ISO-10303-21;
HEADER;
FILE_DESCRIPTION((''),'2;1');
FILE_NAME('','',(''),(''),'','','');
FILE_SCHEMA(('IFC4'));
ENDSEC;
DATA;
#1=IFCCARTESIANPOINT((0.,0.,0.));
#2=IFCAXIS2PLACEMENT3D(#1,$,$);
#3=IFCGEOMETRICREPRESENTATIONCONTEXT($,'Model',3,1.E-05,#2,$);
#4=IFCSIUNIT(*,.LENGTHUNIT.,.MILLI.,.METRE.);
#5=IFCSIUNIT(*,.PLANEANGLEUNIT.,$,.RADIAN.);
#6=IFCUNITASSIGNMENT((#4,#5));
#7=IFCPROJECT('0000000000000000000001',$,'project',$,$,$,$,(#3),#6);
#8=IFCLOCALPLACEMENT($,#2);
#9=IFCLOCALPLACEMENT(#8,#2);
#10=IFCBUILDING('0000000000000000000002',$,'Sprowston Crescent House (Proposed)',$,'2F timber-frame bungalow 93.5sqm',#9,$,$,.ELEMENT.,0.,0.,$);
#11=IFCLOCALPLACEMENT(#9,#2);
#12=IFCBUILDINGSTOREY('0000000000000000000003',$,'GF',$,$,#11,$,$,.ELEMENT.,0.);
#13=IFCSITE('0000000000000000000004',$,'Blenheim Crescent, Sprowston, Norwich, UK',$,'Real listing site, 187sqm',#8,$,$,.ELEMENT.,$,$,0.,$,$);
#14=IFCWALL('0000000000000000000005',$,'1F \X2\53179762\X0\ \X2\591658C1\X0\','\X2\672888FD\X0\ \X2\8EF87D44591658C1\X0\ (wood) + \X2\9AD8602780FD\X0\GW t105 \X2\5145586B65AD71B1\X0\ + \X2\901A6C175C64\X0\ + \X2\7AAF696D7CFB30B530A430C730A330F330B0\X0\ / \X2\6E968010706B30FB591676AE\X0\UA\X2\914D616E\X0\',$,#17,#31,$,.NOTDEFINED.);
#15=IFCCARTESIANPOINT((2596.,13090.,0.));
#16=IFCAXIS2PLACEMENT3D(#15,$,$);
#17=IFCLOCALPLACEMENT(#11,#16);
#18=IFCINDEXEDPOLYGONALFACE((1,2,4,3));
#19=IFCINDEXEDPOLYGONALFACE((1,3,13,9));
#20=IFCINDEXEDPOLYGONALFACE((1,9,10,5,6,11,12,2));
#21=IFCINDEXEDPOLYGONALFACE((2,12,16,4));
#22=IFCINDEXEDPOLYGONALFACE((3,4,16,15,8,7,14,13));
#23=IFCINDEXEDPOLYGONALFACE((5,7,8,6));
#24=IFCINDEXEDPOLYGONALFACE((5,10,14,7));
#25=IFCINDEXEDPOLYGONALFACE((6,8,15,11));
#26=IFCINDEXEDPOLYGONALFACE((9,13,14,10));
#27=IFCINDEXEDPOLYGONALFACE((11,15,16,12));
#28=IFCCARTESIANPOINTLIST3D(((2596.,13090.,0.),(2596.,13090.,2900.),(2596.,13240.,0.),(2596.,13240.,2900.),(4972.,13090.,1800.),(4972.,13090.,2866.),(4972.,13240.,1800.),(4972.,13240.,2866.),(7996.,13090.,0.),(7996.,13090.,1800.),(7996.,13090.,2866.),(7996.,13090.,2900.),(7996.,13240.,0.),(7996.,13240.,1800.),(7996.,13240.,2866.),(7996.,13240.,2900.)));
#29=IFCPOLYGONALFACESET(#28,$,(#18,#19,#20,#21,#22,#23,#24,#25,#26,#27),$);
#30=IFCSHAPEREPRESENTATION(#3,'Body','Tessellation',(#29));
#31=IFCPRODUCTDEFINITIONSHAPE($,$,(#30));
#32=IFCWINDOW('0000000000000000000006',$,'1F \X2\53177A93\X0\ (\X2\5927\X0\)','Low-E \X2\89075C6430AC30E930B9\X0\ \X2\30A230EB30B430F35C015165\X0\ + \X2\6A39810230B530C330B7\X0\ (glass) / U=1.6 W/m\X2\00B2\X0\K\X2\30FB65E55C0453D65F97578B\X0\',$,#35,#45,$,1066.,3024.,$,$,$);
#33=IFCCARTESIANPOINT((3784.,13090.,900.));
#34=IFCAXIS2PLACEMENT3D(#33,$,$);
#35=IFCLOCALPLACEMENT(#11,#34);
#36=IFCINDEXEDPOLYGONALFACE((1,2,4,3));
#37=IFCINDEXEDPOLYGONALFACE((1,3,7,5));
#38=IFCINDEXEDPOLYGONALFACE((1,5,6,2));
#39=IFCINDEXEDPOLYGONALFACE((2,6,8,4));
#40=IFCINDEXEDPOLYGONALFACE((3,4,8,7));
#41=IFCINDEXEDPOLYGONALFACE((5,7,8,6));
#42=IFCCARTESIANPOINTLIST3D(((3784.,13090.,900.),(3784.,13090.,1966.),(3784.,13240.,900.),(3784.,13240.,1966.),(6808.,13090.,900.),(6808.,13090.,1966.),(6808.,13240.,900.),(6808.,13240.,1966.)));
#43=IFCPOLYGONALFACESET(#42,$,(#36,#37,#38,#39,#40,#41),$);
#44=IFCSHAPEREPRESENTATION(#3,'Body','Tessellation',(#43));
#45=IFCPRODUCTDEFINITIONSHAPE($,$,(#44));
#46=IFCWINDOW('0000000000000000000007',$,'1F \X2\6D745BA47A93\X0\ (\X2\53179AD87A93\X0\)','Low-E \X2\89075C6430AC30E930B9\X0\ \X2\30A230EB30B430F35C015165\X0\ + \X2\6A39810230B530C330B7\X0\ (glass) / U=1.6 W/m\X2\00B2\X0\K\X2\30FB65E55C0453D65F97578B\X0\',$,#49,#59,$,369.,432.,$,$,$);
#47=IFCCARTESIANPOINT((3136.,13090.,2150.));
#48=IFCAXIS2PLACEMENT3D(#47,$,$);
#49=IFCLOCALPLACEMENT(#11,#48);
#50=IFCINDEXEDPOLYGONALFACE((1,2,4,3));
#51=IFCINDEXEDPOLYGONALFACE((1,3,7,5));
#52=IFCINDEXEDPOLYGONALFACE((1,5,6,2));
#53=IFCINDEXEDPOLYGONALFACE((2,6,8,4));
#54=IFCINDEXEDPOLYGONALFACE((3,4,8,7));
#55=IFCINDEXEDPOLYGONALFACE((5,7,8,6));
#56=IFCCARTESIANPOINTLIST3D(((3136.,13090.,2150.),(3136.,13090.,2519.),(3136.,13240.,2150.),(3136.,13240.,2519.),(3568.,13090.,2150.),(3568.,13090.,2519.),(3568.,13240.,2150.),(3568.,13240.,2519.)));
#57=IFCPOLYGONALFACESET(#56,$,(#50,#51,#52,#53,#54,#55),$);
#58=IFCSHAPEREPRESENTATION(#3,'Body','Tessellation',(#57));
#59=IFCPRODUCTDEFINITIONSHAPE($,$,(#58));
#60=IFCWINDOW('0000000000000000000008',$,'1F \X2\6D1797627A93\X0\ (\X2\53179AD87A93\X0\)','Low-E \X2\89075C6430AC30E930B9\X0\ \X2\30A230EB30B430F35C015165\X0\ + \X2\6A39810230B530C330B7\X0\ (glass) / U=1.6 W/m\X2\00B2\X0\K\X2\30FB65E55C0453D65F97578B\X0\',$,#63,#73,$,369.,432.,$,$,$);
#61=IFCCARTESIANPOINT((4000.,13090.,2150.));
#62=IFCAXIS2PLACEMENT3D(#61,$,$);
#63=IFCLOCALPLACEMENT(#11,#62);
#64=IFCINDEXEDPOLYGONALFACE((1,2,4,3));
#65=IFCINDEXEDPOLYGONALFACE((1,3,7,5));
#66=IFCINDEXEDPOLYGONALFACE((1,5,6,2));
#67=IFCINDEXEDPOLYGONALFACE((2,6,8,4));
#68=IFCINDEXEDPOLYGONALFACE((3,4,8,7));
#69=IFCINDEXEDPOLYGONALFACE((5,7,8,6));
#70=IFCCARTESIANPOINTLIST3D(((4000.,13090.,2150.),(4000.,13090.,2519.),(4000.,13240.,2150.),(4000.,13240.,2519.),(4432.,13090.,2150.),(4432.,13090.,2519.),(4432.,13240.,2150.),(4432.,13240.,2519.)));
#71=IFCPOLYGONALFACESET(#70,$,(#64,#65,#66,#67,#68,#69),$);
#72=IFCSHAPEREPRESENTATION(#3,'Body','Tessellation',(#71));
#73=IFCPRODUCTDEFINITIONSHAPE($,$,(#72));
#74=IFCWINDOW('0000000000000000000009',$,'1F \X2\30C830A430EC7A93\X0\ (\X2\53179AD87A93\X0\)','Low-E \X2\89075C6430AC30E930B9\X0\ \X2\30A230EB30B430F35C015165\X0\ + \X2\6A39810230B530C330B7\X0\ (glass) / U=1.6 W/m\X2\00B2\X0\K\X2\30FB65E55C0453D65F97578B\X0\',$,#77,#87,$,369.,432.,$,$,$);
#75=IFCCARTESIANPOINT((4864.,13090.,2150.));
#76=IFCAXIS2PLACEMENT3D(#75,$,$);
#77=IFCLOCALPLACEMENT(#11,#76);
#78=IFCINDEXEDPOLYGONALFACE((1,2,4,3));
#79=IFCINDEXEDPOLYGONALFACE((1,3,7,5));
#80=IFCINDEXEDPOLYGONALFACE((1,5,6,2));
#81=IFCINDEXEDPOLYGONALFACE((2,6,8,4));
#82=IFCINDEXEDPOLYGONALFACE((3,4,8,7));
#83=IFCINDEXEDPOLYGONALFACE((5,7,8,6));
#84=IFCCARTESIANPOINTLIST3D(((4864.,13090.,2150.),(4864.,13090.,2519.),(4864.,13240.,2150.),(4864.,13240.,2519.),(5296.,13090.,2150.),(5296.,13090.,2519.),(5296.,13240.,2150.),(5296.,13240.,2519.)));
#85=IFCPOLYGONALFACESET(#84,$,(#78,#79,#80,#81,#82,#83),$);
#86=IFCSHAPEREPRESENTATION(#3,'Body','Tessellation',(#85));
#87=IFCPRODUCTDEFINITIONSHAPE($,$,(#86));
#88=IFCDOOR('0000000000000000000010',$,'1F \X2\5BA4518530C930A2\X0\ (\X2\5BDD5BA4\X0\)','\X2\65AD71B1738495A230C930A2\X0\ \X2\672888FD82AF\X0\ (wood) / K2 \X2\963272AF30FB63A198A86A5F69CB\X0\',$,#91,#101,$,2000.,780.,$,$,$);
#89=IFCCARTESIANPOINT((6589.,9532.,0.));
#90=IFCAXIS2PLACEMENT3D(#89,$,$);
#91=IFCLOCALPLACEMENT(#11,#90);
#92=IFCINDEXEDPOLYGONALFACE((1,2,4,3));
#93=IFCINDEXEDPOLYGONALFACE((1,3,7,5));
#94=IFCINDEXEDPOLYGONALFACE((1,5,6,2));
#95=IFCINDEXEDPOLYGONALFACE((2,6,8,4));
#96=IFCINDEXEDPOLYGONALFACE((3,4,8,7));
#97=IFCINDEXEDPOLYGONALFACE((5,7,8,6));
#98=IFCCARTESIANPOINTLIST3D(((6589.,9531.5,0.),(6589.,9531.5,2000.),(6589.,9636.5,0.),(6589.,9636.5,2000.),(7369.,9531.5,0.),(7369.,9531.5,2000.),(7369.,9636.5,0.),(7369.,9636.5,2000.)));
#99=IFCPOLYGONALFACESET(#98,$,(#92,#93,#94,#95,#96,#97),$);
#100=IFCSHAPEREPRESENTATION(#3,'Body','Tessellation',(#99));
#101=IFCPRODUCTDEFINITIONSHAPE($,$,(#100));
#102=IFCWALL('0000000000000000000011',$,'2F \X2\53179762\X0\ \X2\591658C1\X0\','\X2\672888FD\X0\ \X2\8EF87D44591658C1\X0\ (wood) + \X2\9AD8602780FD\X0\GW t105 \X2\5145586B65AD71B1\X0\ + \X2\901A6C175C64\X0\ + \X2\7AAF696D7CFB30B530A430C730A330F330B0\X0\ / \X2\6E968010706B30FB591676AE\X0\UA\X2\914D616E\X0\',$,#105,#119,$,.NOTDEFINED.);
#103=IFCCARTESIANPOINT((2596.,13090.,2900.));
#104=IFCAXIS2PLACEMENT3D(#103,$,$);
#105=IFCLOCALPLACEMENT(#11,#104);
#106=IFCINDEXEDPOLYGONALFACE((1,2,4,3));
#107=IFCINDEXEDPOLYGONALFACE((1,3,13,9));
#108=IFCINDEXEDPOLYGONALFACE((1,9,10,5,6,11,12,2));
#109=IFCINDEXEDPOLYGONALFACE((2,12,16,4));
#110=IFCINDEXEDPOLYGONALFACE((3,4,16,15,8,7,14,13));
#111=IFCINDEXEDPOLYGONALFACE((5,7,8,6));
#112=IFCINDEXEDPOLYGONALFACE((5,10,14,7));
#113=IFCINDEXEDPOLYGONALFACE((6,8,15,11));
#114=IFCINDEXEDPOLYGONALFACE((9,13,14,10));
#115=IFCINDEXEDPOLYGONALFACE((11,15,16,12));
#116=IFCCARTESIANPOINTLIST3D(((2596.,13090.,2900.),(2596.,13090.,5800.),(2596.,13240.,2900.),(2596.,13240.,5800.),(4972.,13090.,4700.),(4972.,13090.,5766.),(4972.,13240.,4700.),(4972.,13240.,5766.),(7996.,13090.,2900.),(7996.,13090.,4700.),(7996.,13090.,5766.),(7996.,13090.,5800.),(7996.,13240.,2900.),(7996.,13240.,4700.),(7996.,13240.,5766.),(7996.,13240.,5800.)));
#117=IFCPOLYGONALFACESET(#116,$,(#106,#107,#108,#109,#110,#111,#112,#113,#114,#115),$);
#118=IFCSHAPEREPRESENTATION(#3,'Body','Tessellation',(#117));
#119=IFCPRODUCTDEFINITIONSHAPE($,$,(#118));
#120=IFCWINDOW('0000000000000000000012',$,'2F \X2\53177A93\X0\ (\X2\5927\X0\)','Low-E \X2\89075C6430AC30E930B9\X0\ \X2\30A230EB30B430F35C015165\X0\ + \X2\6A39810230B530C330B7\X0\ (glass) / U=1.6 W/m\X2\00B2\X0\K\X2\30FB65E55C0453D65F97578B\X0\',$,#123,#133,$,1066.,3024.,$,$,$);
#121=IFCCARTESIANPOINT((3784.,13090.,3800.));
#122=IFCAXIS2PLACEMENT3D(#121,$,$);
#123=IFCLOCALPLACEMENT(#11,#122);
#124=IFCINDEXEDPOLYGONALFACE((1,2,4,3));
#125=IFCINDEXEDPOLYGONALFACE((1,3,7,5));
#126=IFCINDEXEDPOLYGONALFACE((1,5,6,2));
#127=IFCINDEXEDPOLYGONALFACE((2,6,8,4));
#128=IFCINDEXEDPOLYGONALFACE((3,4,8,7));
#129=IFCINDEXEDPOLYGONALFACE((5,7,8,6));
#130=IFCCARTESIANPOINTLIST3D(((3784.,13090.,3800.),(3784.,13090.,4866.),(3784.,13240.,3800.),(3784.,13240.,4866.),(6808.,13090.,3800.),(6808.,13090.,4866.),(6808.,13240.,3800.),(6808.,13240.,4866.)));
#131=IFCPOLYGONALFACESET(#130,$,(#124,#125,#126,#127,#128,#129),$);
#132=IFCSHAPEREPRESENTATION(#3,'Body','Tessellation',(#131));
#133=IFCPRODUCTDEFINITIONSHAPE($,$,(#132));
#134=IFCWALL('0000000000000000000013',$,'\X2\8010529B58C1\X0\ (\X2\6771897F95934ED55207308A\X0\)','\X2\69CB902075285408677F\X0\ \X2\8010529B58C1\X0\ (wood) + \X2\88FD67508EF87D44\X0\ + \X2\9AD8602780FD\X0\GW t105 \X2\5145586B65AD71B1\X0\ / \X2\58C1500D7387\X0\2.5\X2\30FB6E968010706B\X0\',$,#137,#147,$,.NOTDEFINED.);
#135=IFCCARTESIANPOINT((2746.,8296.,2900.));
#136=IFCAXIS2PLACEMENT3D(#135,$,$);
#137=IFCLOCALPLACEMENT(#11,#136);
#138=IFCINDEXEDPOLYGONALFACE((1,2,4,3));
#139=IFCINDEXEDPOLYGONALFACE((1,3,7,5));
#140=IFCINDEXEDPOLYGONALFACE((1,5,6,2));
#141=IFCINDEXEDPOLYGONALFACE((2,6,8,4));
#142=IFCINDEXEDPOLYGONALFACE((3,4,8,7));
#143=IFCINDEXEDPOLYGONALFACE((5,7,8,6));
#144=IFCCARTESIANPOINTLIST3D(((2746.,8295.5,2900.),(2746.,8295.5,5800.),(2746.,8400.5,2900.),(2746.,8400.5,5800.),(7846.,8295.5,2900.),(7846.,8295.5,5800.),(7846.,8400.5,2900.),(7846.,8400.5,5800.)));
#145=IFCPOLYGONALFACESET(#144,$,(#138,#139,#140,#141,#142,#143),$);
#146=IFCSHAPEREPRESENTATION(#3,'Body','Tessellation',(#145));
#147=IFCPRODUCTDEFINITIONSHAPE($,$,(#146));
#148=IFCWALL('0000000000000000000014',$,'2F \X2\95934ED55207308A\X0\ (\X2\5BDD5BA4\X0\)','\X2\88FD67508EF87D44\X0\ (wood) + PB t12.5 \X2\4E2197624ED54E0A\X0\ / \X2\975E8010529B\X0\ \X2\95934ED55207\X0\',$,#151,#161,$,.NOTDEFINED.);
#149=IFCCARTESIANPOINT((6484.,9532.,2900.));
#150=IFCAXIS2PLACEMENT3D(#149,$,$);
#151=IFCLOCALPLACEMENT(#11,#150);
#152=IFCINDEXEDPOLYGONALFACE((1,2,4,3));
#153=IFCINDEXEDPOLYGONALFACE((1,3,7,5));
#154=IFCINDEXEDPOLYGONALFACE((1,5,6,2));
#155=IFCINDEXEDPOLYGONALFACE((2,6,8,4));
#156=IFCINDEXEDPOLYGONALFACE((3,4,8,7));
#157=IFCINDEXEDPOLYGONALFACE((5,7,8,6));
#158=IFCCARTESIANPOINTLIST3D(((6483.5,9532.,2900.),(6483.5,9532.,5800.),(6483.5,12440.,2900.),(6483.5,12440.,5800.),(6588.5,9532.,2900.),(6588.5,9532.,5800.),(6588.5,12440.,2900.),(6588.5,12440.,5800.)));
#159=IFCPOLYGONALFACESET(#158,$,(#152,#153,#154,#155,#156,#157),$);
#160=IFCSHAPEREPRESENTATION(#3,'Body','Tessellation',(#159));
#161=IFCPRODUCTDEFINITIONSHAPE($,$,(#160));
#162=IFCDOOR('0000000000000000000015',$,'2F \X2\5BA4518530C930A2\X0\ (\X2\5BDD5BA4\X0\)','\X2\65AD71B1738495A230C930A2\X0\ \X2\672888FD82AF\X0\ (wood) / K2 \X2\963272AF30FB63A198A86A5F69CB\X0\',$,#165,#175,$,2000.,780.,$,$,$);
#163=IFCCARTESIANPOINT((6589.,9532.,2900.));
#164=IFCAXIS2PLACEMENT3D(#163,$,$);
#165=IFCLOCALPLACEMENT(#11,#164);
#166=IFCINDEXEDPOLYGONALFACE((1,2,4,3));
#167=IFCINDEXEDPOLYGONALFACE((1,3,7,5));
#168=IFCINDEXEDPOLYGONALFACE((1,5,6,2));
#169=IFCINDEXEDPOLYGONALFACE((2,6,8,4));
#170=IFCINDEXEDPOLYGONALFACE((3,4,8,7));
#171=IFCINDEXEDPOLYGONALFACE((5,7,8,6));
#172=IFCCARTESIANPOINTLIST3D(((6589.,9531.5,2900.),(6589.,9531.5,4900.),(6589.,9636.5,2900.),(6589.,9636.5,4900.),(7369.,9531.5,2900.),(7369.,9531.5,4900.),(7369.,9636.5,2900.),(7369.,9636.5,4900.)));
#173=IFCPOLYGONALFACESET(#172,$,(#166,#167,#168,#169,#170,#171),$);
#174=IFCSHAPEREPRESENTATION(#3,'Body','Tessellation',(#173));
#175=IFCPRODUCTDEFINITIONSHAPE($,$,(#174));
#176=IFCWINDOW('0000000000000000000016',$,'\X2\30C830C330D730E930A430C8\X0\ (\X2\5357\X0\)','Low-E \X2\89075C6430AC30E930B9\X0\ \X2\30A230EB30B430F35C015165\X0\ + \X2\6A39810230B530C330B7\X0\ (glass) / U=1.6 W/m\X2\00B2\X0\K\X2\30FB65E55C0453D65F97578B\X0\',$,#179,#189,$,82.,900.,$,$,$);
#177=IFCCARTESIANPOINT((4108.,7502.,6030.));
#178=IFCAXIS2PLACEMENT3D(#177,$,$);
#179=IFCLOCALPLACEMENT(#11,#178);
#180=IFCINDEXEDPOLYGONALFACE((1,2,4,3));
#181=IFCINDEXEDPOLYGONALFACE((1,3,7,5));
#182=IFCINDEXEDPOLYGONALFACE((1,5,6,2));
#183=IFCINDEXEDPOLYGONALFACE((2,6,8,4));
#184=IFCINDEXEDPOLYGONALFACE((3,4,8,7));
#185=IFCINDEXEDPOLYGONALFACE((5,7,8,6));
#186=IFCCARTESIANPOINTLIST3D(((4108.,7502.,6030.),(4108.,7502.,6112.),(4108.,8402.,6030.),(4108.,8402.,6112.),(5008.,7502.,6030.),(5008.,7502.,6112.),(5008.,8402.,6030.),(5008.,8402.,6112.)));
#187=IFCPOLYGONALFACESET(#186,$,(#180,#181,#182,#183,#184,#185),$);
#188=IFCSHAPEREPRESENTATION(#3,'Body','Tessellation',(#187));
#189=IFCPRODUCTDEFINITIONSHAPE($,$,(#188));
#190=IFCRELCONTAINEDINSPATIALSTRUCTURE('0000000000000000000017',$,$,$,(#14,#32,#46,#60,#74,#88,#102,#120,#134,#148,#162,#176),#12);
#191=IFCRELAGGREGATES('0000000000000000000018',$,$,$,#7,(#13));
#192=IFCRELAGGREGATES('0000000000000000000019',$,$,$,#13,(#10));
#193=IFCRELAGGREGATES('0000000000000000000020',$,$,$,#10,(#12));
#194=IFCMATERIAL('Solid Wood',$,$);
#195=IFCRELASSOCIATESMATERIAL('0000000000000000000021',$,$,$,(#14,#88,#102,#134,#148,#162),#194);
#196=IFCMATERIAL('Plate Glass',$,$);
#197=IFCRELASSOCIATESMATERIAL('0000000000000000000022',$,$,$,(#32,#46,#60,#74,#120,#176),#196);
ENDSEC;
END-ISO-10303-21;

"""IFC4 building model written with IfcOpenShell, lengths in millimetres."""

from ifc_helpers import new_model, si_unit, frame, frame_2d, origin, place, context, project, spatial, rectangle, extrude, material, element, fill, save


model = new_model("IFC4")

# Units and contexts
model_context = context("Model", 3, precision=1e-05, world=origin())
ifc_project = project(units=[si_unit("LENGTHUNIT", "METRE", prefix="MILLI"), si_unit("PLANEANGLEUNIT", "RADIAN")], contexts=[model_context])

# Site, building, storey
site_placement = place(None, origin())
site = spatial("IfcSite", under=ifc_project, at=site_placement, Name="Blenheim Crescent, Sprowston, Norwich, UK", ObjectType="Real listing site, 187sqm", CompositionType="ELEMENT", RefElevation=0.0)
building_placement = place(site_placement, origin())
building = spatial("IfcBuilding", under=site, at=building_placement, Name="Sprowston Crescent House (Proposed)", ObjectType="2F timber-frame bungalow 93.5sqm", CompositionType="ELEMENT", ElevationOfRefHeight=0.0, ElevationOfTerrain=0.0)
storey_placement = place(building_placement, origin())
storey = spatial("IfcBuildingStorey", under=building, at=storey_placement, Name="GF", CompositionType="ELEMENT", Elevation=0.0)

# Wall, openings, windows
ifc_material_1 = material(Name="Solid Wood")
wall_1_placement = place(storey_placement, frame((2596.0, 13090.0, 0.0)))
wall_1 = element("IfcWall", 1, at=wall_1_placement, inside=storey, material=ifc_material_1, Name="1F 北面 外壁", Description="木製 軸組外壁 (wood) + 高性能GW t105 充填断熱 + 通気層 + 窯業系サイディング / 準耐火・外皮UA配慮", PredefinedType="NOTDEFINED", context=model_context, shape_type="SweptSolid", body=[
    extrude(rectangle(XDim=5400.0, YDim=150.0, at=frame_2d((2700.0, 75.0))), frame((2596.0, 13090.0, 0.0)), (0.0, 0.0, 1.0), 2900.0),
])
opening_1_placement = place(storey_placement, frame((3784.0, 13090.0, 900.0)))
opening_1 = element("IfcOpeningElement", 2, at=opening_1_placement, cuts=wall_1, PredefinedType="NOTDEFINED", context=model_context, shape_type="SweptSolid", body=[
    extrude(rectangle(XDim=3024.0, YDim=150.0, at=frame_2d((1512.0, 75.0))), frame((3784.0, 13090.0, 900.0)), (0.0, 0.0, 1.0), 1066.0),
])
opening_2_placement = place(storey_placement, frame((3136.0, 13090.0, 2150.0)))
opening_2 = element("IfcOpeningElement", 3, at=opening_2_placement, cuts=wall_1, PredefinedType="NOTDEFINED", context=model_context, shape_type="SweptSolid", body=[
    extrude(rectangle(XDim=432.0, YDim=150.0, at=frame_2d((216.0, 75.0))), frame((3136.0, 13090.0, 2150.0)), (0.0, 0.0, 1.0), 369.0),
])
opening_3_placement = place(storey_placement, frame((4000.0, 13090.0, 2150.0)))
opening_3 = element("IfcOpeningElement", 4, at=opening_3_placement, cuts=wall_1, PredefinedType="NOTDEFINED", context=model_context, shape_type="SweptSolid", body=[
    extrude(rectangle(XDim=432.0, YDim=150.0, at=frame_2d((216.0, 75.0))), frame((4000.0, 13090.0, 2150.0)), (0.0, 0.0, 1.0), 369.0),
])
opening_4_placement = place(storey_placement, frame((4864.0, 13090.0, 2150.0)))
opening_4 = element("IfcOpeningElement", 5, at=opening_4_placement, cuts=wall_1, PredefinedType="NOTDEFINED", context=model_context, shape_type="SweptSolid", body=[
    extrude(rectangle(XDim=432.0, YDim=150.0, at=frame_2d((216.0, 75.0))), frame((4864.0, 13090.0, 2150.0)), (0.0, 0.0, 1.0), 369.0),
])
ifc_material_2 = material(Name="Plate Glass")
window_1_placement = place(storey_placement, frame((3784.0, 13090.0, 900.0)))
window_1 = element("IfcWindow", 6, at=window_1_placement, inside=storey, material=ifc_material_2, Name="1F 北窓 (大)", Description="Low-E 複層ガラス アルゴン封入 + 樹脂サッシ (glass) / U=1.6 W/m²K・日射取得型", OverallHeight=1066.0, OverallWidth=3024.0, context=model_context, shape_type="SweptSolid", body=[
    extrude(rectangle(XDim=3024.0, YDim=150.0, at=frame_2d((1512.0, 75.0))), frame((3784.0, 13090.0, 900.0)), (0.0, 0.0, 1.0), 1066.0),
])
fill(opening_1, window_1)
window_2_placement = place(storey_placement, frame((3136.0, 13090.0, 2150.0)))
window_2 = element("IfcWindow", 7, at=window_2_placement, inside=storey, material=ifc_material_2, Name="1F 浴室窓 (北高窓)", Description="Low-E 複層ガラス アルゴン封入 + 樹脂サッシ (glass) / U=1.6 W/m²K・日射取得型", OverallHeight=369.0, OverallWidth=432.0, context=model_context, shape_type="SweptSolid", body=[
    extrude(rectangle(XDim=432.0, YDim=150.0, at=frame_2d((216.0, 75.0))), frame((3136.0, 13090.0, 2150.0)), (0.0, 0.0, 1.0), 369.0),
])
fill(opening_2, window_2)
window_3_placement = place(storey_placement, frame((4000.0, 13090.0, 2150.0)))
window_3 = element("IfcWindow", 8, at=window_3_placement, inside=storey, material=ifc_material_2, Name="1F 洗面窓 (北高窓)", Description="Low-E 複層ガラス アルゴン封入 + 樹脂サッシ (glass) / U=1.6 W/m²K・日射取得型", OverallHeight=369.0, OverallWidth=432.0, context=model_context, shape_type="SweptSolid", body=[
    extrude(rectangle(XDim=432.0, YDim=150.0, at=frame_2d((216.0, 75.0))), frame((4000.0, 13090.0, 2150.0)), (0.0, 0.0, 1.0), 369.0),
])
fill(opening_3, window_3)
window_4_placement = place(storey_placement, frame((4864.0, 13090.0, 2150.0)))
window_4 = element("IfcWindow", 9, at=window_4_placement, inside=storey, material=ifc_material_2, Name="1F トイレ窓 (北高窓)", Description="Low-E 複層ガラス アルゴン封入 + 樹脂サッシ (glass) / U=1.6 W/m²K・日射取得型", OverallHeight=369.0, OverallWidth=432.0, context=model_context, shape_type="SweptSolid", body=[
    extrude(rectangle(XDim=432.0, YDim=150.0, at=frame_2d((216.0, 75.0))), frame((4864.0, 13090.0, 2150.0)), (0.0, 0.0, 1.0), 369.0),
])
fill(opening_4, window_4)

# Door
door_1_placement = place(storey_placement, frame((6589.0, 9532.0, 0.0)))
element("IfcDoor", 10, at=door_1_placement, inside=storey, material=ifc_material_1, Name="1F 室内ドア (寝室)", Description="断熱玄関ドア 木製芯 (wood) / K2 防犯・採風機構", OverallHeight=2000.0, OverallWidth=780.0, context=model_context, shape_type="SweptSolid", body=[
    extrude(rectangle(XDim=780.0, YDim=105.0, at=frame_2d((390.0, 52.0))), frame((6589.0, 9532.0, 0.0)), (0.0, 0.0, 1.0), 2000.0),
])

# Wall, opening, window
wall_2_placement = place(storey_placement, frame((2596.0, 13090.0, 2900.0)))
wall_2 = element("IfcWall", 11, at=wall_2_placement, inside=storey, material=ifc_material_1, Name="2F 北面 外壁", Description="木製 軸組外壁 (wood) + 高性能GW t105 充填断熱 + 通気層 + 窯業系サイディング / 準耐火・外皮UA配慮", PredefinedType="NOTDEFINED", context=model_context, shape_type="SweptSolid", body=[
    extrude(rectangle(XDim=5400.0, YDim=150.0, at=frame_2d((2700.0, 75.0))), frame((2596.0, 13090.0, 2900.0)), (0.0, 0.0, 1.0), 2900.0),
])
opening_5_placement = place(storey_placement, frame((3784.0, 13090.0, 3800.0)))
opening_5 = element("IfcOpeningElement", 12, at=opening_5_placement, cuts=wall_2, PredefinedType="NOTDEFINED", context=model_context, shape_type="SweptSolid", body=[
    extrude(rectangle(XDim=3024.0, YDim=150.0, at=frame_2d((1512.0, 75.0))), frame((3784.0, 13090.0, 3800.0)), (0.0, 0.0, 1.0), 1066.0),
])
window_5_placement = place(storey_placement, frame((3784.0, 13090.0, 3800.0)))
window_5 = element("IfcWindow", 13, at=window_5_placement, inside=storey, material=ifc_material_2, Name="2F 北窓 (大)", Description="Low-E 複層ガラス アルゴン封入 + 樹脂サッシ (glass) / U=1.6 W/m²K・日射取得型", OverallHeight=1066.0, OverallWidth=3024.0, context=model_context, shape_type="SweptSolid", body=[
    extrude(rectangle(XDim=3024.0, YDim=150.0, at=frame_2d((1512.0, 75.0))), frame((3784.0, 13090.0, 3800.0)), (0.0, 0.0, 1.0), 1066.0),
])
fill(opening_5, window_5)

# Walls
wall_3_placement = place(storey_placement, frame((2746.0, 8296.0, 2900.0)))
element("IfcWall", 14, at=wall_3_placement, inside=storey, material=ifc_material_1, Name="耐力壁 (東西間仕切り)", Description="構造用合板 耐力壁 (wood) + 製材軸組 + 高性能GW t105 充填断熱 / 壁倍率2.5・準耐火", PredefinedType="NOTDEFINED", context=model_context, shape_type="SweptSolid", body=[
    extrude(rectangle(XDim=5100.0, YDim=105.0, at=frame_2d((2550.0, 52.0))), frame((2746.0, 8296.0, 2900.0)), (0.0, 0.0, 1.0), 2900.0),
])
wall_4_placement = place(storey_placement, frame((6484.0, 9532.0, 2900.0)))
element("IfcWall", 15, at=wall_4_placement, inside=storey, material=ifc_material_1, Name="2F 間仕切り (寝室)", Description="製材軸組 (wood) + PB t12.5 両面仕上 / 非耐力 間仕切", PredefinedType="NOTDEFINED", context=model_context, shape_type="SweptSolid", body=[
    extrude(rectangle(XDim=105.0, YDim=2908.0, at=frame_2d((52.0, 1454.0))), frame((6484.0, 9532.0, 2900.0)), (0.0, 0.0, 1.0), 2900.0),
])

# Door
door_2_placement = place(storey_placement, frame((6589.0, 9532.0, 2900.0)))
element("IfcDoor", 16, at=door_2_placement, inside=storey, material=ifc_material_1, Name="2F 室内ドア (寝室)", Description="断熱玄関ドア 木製芯 (wood) / K2 防犯・採風機構", OverallHeight=2000.0, OverallWidth=780.0, context=model_context, shape_type="SweptSolid", body=[
    extrude(rectangle(XDim=780.0, YDim=105.0, at=frame_2d((390.0, 52.0))), frame((6589.0, 9532.0, 2900.0)), (0.0, 0.0, 1.0), 2000.0),
])

# Window
window_6_placement = place(storey_placement, frame((4108.0, 7502.0, 6030.0)))
element("IfcWindow", 17, at=window_6_placement, inside=storey, material=ifc_material_2, Name="トップライト (南)", Description="Low-E 複層ガラス アルゴン封入 + 樹脂サッシ (glass) / U=1.6 W/m²K・日射取得型", OverallHeight=82.0, OverallWidth=900.0, context=model_context, shape_type="SweptSolid", body=[
    extrude(rectangle(XDim=900.0, YDim=900.0, at=frame_2d((450.0, 450.0))), frame((4108.0, 7502.0, 6030.0)), (0.0, 0.0, 1.0), 82.0),
])

save(model, "model.ifc")
